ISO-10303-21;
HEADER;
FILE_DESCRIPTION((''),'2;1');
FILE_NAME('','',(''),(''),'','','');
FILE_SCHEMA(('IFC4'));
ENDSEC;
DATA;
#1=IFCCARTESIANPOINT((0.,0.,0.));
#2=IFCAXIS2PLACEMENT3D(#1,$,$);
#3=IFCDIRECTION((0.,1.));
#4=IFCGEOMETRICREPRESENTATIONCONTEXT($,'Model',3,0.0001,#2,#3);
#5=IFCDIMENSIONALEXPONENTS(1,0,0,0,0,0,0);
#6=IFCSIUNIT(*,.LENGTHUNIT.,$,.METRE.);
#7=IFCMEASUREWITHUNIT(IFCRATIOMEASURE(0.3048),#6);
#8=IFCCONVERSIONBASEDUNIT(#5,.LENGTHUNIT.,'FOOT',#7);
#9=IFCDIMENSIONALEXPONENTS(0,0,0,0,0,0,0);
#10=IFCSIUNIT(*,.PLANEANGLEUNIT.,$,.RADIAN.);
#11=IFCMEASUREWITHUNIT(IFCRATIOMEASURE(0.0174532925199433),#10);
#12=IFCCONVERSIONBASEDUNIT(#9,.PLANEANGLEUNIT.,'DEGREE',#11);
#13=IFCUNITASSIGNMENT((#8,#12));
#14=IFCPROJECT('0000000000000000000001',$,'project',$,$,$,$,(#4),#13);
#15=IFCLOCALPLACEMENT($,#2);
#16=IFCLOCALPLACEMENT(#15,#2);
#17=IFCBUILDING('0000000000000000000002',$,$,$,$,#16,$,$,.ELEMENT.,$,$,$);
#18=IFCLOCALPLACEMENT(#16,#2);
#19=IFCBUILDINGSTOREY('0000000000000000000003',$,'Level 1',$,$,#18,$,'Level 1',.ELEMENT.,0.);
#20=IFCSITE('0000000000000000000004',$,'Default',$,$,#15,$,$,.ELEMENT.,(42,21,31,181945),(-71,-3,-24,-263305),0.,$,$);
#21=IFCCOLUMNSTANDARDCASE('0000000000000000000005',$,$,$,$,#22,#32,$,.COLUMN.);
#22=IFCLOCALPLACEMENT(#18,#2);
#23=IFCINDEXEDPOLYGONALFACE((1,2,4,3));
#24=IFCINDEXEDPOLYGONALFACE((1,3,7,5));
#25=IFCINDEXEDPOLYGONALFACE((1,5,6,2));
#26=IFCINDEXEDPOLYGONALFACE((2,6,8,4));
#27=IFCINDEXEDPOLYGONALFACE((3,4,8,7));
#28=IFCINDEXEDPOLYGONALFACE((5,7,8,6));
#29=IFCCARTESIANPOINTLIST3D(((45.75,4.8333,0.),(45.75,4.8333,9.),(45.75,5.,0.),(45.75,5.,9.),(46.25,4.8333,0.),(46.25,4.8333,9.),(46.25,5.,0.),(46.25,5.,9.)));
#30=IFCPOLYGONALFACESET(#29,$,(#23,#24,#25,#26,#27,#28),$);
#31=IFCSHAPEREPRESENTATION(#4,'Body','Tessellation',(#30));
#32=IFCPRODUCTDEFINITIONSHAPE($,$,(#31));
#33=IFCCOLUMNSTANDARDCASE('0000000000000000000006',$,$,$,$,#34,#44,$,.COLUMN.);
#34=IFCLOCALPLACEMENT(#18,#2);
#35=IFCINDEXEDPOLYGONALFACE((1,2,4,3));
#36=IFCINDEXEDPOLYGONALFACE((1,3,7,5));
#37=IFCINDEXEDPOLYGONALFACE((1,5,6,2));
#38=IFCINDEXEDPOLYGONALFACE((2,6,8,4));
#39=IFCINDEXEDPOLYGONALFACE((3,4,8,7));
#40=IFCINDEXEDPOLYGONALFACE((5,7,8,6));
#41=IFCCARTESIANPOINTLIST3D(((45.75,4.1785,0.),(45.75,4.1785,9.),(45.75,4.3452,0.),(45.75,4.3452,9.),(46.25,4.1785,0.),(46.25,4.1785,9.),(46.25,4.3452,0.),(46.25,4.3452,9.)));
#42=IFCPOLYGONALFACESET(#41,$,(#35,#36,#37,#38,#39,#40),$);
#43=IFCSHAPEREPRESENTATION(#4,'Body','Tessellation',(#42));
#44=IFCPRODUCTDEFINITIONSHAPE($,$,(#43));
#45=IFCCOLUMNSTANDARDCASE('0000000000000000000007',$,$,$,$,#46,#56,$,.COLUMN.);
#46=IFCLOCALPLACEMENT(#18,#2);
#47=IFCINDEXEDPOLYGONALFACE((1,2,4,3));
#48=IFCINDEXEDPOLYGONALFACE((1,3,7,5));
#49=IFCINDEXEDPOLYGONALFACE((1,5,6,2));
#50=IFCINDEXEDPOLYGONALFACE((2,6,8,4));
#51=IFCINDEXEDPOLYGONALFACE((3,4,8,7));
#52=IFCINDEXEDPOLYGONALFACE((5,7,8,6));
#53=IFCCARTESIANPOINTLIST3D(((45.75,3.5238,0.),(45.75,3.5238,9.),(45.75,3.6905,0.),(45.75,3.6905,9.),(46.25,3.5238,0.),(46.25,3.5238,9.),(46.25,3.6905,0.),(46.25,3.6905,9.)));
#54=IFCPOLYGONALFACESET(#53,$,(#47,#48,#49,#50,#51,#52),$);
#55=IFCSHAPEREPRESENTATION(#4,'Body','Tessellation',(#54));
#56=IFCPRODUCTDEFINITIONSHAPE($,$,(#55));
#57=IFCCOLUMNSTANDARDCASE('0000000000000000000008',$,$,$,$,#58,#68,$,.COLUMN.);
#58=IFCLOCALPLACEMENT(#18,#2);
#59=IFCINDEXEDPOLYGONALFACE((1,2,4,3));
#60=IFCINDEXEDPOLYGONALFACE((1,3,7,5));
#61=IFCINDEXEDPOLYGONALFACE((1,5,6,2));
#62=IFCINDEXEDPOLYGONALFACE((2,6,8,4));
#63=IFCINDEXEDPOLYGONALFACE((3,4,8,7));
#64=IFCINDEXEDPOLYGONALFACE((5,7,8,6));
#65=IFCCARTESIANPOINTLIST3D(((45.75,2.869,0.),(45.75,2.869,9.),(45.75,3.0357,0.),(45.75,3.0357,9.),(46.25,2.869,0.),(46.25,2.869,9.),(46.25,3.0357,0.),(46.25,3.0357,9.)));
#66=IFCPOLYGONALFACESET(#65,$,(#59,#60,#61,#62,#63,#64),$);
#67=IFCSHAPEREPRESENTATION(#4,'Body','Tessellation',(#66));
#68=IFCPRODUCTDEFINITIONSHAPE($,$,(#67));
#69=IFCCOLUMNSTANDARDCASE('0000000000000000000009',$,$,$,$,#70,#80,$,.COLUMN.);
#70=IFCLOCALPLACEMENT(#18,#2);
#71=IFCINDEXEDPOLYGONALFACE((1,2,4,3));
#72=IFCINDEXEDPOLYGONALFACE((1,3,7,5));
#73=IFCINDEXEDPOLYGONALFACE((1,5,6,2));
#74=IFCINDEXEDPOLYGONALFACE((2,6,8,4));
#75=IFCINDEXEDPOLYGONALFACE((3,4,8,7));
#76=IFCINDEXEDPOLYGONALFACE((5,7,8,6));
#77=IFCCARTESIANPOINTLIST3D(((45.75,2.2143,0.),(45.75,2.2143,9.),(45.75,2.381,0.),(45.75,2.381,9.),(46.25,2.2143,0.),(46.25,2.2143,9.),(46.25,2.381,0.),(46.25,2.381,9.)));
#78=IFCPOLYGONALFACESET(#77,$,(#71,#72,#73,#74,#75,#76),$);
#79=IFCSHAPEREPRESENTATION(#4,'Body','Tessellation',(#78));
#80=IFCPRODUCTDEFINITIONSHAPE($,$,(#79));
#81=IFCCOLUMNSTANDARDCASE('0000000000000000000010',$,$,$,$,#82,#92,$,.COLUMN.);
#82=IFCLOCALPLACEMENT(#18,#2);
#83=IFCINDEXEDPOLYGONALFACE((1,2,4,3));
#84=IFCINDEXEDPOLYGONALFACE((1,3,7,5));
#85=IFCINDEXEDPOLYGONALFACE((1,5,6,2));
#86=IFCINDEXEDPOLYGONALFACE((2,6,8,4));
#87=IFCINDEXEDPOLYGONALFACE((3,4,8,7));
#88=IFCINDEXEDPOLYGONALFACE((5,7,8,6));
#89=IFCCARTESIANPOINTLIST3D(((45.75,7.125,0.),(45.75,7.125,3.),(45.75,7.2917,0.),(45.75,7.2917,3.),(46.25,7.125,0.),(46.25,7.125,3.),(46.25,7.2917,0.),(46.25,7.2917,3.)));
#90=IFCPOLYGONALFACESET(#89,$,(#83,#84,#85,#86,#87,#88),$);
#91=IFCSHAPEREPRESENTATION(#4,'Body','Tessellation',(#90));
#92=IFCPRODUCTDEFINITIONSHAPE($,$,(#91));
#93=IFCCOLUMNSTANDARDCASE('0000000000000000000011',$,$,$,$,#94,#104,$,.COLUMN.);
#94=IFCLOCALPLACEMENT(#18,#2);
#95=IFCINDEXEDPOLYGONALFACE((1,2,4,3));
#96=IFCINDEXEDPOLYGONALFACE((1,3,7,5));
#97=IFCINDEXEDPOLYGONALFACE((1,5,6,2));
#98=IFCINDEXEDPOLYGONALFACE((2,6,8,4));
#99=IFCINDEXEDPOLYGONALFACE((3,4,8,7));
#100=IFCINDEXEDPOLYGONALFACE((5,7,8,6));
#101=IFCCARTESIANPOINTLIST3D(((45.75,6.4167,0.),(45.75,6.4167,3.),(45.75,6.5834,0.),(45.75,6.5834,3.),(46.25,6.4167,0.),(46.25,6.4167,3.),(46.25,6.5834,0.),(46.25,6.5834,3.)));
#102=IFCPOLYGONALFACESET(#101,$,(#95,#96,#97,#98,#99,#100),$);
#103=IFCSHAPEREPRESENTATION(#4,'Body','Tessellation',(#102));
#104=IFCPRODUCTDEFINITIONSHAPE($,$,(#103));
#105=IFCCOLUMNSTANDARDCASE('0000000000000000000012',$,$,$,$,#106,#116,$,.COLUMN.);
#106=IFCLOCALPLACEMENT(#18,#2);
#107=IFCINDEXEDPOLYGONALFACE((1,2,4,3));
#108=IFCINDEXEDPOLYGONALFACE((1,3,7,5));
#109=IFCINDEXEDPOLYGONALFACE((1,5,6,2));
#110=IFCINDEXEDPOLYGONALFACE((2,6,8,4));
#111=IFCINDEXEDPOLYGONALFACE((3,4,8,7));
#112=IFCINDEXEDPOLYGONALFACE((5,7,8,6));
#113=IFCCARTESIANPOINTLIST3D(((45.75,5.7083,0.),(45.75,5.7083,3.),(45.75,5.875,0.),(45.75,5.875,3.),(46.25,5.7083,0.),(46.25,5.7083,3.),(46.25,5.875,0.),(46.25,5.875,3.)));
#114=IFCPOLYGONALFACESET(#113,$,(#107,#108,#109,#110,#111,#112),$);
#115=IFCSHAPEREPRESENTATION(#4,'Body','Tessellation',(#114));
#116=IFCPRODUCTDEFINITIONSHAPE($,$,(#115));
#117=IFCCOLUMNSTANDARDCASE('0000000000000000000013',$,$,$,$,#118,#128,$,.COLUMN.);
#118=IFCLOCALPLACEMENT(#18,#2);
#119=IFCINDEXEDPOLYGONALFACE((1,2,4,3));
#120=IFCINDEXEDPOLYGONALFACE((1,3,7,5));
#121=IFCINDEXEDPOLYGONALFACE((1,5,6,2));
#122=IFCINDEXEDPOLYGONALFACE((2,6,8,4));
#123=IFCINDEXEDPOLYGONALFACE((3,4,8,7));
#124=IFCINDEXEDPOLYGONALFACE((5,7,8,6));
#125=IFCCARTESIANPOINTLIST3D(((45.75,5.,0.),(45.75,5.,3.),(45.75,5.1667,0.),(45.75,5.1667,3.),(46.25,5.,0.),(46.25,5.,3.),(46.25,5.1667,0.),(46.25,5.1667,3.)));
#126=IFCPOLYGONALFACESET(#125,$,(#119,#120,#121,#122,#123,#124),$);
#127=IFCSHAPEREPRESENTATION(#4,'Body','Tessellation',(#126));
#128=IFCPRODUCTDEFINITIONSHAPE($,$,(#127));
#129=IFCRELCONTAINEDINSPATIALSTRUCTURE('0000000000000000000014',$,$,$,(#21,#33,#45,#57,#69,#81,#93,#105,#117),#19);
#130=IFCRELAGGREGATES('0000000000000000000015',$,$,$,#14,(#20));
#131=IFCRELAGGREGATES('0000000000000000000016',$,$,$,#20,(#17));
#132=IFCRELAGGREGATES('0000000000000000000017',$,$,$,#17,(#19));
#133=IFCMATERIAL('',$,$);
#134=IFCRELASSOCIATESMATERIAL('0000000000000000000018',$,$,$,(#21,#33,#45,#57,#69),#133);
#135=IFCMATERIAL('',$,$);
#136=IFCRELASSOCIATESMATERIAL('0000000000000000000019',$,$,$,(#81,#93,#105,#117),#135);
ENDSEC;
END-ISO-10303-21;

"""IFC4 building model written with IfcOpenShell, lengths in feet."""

from ifc_helpers import new_model, entity, si_unit, converted_unit, direction, frame, origin, place, context, project, spatial, rectangle, extrude, material, element, save


model = new_model("IFC4")

# Units and contexts
model_context = context("Model", 3, precision=0.0001, world=origin(), true_north=direction((0.0, 1.0)))
ifc_project = project(units=[converted_unit("LENGTHUNIT", "FOOT", entity("IfcRatioMeasure", 0.3048), si_unit("LENGTHUNIT", "METRE"), dimensions=[1, 0, 0, 0, 0, 0, 0]), converted_unit("PLANEANGLEUNIT", "DEGREE", entity("IfcRatioMeasure", 0.0174532925199433), si_unit("PLANEANGLEUNIT", "RADIAN"), dimensions=[0, 0, 0, 0, 0, 0, 0])], contexts=[model_context])

# Site, building, storey
site_placement = place(None, origin())
site = spatial("IfcSite", under=ifc_project, at=site_placement, Name="Default", CompositionType="ELEMENT", RefLatitude=(42, 21, 31, 181945), RefLongitude=(-71, -3, -24, -263305), RefElevation=0.0)
building_placement = place(site_placement, origin())
building = spatial("IfcBuilding", under=site, at=building_placement, CompositionType="ELEMENT")
storey_placement = place(building_placement, origin())
storey = spatial("IfcBuildingStorey", under=building, at=storey_placement, Name="Level 1", LongName="Level 1", CompositionType="ELEMENT", Elevation=0.0)

# Columns
ifc_material_1 = material(Name="")
placement = place(storey_placement, frame((46.0, 46.25, 0.0), z_axis=(0.0, 0.0, 1.0), x_axis=(0.0, -1.0, 0.0)))
for number, where, z_axis, x_axis in (
    (1, (41.3334, 0.0, 0.0), (0.0, 0.0, 1.0), (1.0, 0.0, 0.0)),
    (2, (41.9881, 0.0, 0.0), (0.0, 0.0, 1.0), (1.0, 0.0, 0.0)),
    (3, (42.6429, 0.0, 0.0), (0.0, 0.0, 1.0), (1.0, 0.0, 0.0)),
    (4, (43.2976, 0.0, 0.0), (0.0, 0.0, 1.0), (1.0, 0.0, 0.0)),
    (5, (43.9524, 0.0, 0.0), (0.0, 0.0, 1.0), (1.0, 0.0, 0.0)),
):
    element("IfcColumnStandardCase", number, at=place(placement, frame(where, z_axis=z_axis, x_axis=x_axis)), inside=storey, material=ifc_material_1, PredefinedType="COLUMN", context=model_context, shape_type="SweptSolid", body=[
        extrude(rectangle(XDim=0.1667, YDim=0.5), origin(), (0.0, 0.0, 1.0), 9.0),
    ])
ifc_material_2 = material(Name="")
for number, where, z_axis, x_axis in (
    (6, (39.0417, 0.0, 0.0), (0.0, 0.0, 1.0), (1.0, 0.0, 0.0)),
    (7, (39.75, 0.0, 0.0), (0.0, 0.0, 1.0), (1.0, 0.0, 0.0)),
    (8, (40.4583, 0.0, 0.0), (0.0, 0.0, 1.0), (1.0, 0.0, 0.0)),
    (9, (41.1667, 0.0, 0.0), (0.0, 0.0, 1.0), (1.0, 0.0, 0.0)),
):
    element("IfcColumnStandardCase", number, at=place(placement, frame(where, z_axis=z_axis, x_axis=x_axis)), inside=storey, material=ifc_material_2, PredefinedType="COLUMN", context=model_context, shape_type="SweptSolid", body=[
        extrude(rectangle(XDim=0.1667, YDim=0.5), origin(), (0.0, 0.0, 1.0), 3.0),
    ])

save(model, "model.ifc")
